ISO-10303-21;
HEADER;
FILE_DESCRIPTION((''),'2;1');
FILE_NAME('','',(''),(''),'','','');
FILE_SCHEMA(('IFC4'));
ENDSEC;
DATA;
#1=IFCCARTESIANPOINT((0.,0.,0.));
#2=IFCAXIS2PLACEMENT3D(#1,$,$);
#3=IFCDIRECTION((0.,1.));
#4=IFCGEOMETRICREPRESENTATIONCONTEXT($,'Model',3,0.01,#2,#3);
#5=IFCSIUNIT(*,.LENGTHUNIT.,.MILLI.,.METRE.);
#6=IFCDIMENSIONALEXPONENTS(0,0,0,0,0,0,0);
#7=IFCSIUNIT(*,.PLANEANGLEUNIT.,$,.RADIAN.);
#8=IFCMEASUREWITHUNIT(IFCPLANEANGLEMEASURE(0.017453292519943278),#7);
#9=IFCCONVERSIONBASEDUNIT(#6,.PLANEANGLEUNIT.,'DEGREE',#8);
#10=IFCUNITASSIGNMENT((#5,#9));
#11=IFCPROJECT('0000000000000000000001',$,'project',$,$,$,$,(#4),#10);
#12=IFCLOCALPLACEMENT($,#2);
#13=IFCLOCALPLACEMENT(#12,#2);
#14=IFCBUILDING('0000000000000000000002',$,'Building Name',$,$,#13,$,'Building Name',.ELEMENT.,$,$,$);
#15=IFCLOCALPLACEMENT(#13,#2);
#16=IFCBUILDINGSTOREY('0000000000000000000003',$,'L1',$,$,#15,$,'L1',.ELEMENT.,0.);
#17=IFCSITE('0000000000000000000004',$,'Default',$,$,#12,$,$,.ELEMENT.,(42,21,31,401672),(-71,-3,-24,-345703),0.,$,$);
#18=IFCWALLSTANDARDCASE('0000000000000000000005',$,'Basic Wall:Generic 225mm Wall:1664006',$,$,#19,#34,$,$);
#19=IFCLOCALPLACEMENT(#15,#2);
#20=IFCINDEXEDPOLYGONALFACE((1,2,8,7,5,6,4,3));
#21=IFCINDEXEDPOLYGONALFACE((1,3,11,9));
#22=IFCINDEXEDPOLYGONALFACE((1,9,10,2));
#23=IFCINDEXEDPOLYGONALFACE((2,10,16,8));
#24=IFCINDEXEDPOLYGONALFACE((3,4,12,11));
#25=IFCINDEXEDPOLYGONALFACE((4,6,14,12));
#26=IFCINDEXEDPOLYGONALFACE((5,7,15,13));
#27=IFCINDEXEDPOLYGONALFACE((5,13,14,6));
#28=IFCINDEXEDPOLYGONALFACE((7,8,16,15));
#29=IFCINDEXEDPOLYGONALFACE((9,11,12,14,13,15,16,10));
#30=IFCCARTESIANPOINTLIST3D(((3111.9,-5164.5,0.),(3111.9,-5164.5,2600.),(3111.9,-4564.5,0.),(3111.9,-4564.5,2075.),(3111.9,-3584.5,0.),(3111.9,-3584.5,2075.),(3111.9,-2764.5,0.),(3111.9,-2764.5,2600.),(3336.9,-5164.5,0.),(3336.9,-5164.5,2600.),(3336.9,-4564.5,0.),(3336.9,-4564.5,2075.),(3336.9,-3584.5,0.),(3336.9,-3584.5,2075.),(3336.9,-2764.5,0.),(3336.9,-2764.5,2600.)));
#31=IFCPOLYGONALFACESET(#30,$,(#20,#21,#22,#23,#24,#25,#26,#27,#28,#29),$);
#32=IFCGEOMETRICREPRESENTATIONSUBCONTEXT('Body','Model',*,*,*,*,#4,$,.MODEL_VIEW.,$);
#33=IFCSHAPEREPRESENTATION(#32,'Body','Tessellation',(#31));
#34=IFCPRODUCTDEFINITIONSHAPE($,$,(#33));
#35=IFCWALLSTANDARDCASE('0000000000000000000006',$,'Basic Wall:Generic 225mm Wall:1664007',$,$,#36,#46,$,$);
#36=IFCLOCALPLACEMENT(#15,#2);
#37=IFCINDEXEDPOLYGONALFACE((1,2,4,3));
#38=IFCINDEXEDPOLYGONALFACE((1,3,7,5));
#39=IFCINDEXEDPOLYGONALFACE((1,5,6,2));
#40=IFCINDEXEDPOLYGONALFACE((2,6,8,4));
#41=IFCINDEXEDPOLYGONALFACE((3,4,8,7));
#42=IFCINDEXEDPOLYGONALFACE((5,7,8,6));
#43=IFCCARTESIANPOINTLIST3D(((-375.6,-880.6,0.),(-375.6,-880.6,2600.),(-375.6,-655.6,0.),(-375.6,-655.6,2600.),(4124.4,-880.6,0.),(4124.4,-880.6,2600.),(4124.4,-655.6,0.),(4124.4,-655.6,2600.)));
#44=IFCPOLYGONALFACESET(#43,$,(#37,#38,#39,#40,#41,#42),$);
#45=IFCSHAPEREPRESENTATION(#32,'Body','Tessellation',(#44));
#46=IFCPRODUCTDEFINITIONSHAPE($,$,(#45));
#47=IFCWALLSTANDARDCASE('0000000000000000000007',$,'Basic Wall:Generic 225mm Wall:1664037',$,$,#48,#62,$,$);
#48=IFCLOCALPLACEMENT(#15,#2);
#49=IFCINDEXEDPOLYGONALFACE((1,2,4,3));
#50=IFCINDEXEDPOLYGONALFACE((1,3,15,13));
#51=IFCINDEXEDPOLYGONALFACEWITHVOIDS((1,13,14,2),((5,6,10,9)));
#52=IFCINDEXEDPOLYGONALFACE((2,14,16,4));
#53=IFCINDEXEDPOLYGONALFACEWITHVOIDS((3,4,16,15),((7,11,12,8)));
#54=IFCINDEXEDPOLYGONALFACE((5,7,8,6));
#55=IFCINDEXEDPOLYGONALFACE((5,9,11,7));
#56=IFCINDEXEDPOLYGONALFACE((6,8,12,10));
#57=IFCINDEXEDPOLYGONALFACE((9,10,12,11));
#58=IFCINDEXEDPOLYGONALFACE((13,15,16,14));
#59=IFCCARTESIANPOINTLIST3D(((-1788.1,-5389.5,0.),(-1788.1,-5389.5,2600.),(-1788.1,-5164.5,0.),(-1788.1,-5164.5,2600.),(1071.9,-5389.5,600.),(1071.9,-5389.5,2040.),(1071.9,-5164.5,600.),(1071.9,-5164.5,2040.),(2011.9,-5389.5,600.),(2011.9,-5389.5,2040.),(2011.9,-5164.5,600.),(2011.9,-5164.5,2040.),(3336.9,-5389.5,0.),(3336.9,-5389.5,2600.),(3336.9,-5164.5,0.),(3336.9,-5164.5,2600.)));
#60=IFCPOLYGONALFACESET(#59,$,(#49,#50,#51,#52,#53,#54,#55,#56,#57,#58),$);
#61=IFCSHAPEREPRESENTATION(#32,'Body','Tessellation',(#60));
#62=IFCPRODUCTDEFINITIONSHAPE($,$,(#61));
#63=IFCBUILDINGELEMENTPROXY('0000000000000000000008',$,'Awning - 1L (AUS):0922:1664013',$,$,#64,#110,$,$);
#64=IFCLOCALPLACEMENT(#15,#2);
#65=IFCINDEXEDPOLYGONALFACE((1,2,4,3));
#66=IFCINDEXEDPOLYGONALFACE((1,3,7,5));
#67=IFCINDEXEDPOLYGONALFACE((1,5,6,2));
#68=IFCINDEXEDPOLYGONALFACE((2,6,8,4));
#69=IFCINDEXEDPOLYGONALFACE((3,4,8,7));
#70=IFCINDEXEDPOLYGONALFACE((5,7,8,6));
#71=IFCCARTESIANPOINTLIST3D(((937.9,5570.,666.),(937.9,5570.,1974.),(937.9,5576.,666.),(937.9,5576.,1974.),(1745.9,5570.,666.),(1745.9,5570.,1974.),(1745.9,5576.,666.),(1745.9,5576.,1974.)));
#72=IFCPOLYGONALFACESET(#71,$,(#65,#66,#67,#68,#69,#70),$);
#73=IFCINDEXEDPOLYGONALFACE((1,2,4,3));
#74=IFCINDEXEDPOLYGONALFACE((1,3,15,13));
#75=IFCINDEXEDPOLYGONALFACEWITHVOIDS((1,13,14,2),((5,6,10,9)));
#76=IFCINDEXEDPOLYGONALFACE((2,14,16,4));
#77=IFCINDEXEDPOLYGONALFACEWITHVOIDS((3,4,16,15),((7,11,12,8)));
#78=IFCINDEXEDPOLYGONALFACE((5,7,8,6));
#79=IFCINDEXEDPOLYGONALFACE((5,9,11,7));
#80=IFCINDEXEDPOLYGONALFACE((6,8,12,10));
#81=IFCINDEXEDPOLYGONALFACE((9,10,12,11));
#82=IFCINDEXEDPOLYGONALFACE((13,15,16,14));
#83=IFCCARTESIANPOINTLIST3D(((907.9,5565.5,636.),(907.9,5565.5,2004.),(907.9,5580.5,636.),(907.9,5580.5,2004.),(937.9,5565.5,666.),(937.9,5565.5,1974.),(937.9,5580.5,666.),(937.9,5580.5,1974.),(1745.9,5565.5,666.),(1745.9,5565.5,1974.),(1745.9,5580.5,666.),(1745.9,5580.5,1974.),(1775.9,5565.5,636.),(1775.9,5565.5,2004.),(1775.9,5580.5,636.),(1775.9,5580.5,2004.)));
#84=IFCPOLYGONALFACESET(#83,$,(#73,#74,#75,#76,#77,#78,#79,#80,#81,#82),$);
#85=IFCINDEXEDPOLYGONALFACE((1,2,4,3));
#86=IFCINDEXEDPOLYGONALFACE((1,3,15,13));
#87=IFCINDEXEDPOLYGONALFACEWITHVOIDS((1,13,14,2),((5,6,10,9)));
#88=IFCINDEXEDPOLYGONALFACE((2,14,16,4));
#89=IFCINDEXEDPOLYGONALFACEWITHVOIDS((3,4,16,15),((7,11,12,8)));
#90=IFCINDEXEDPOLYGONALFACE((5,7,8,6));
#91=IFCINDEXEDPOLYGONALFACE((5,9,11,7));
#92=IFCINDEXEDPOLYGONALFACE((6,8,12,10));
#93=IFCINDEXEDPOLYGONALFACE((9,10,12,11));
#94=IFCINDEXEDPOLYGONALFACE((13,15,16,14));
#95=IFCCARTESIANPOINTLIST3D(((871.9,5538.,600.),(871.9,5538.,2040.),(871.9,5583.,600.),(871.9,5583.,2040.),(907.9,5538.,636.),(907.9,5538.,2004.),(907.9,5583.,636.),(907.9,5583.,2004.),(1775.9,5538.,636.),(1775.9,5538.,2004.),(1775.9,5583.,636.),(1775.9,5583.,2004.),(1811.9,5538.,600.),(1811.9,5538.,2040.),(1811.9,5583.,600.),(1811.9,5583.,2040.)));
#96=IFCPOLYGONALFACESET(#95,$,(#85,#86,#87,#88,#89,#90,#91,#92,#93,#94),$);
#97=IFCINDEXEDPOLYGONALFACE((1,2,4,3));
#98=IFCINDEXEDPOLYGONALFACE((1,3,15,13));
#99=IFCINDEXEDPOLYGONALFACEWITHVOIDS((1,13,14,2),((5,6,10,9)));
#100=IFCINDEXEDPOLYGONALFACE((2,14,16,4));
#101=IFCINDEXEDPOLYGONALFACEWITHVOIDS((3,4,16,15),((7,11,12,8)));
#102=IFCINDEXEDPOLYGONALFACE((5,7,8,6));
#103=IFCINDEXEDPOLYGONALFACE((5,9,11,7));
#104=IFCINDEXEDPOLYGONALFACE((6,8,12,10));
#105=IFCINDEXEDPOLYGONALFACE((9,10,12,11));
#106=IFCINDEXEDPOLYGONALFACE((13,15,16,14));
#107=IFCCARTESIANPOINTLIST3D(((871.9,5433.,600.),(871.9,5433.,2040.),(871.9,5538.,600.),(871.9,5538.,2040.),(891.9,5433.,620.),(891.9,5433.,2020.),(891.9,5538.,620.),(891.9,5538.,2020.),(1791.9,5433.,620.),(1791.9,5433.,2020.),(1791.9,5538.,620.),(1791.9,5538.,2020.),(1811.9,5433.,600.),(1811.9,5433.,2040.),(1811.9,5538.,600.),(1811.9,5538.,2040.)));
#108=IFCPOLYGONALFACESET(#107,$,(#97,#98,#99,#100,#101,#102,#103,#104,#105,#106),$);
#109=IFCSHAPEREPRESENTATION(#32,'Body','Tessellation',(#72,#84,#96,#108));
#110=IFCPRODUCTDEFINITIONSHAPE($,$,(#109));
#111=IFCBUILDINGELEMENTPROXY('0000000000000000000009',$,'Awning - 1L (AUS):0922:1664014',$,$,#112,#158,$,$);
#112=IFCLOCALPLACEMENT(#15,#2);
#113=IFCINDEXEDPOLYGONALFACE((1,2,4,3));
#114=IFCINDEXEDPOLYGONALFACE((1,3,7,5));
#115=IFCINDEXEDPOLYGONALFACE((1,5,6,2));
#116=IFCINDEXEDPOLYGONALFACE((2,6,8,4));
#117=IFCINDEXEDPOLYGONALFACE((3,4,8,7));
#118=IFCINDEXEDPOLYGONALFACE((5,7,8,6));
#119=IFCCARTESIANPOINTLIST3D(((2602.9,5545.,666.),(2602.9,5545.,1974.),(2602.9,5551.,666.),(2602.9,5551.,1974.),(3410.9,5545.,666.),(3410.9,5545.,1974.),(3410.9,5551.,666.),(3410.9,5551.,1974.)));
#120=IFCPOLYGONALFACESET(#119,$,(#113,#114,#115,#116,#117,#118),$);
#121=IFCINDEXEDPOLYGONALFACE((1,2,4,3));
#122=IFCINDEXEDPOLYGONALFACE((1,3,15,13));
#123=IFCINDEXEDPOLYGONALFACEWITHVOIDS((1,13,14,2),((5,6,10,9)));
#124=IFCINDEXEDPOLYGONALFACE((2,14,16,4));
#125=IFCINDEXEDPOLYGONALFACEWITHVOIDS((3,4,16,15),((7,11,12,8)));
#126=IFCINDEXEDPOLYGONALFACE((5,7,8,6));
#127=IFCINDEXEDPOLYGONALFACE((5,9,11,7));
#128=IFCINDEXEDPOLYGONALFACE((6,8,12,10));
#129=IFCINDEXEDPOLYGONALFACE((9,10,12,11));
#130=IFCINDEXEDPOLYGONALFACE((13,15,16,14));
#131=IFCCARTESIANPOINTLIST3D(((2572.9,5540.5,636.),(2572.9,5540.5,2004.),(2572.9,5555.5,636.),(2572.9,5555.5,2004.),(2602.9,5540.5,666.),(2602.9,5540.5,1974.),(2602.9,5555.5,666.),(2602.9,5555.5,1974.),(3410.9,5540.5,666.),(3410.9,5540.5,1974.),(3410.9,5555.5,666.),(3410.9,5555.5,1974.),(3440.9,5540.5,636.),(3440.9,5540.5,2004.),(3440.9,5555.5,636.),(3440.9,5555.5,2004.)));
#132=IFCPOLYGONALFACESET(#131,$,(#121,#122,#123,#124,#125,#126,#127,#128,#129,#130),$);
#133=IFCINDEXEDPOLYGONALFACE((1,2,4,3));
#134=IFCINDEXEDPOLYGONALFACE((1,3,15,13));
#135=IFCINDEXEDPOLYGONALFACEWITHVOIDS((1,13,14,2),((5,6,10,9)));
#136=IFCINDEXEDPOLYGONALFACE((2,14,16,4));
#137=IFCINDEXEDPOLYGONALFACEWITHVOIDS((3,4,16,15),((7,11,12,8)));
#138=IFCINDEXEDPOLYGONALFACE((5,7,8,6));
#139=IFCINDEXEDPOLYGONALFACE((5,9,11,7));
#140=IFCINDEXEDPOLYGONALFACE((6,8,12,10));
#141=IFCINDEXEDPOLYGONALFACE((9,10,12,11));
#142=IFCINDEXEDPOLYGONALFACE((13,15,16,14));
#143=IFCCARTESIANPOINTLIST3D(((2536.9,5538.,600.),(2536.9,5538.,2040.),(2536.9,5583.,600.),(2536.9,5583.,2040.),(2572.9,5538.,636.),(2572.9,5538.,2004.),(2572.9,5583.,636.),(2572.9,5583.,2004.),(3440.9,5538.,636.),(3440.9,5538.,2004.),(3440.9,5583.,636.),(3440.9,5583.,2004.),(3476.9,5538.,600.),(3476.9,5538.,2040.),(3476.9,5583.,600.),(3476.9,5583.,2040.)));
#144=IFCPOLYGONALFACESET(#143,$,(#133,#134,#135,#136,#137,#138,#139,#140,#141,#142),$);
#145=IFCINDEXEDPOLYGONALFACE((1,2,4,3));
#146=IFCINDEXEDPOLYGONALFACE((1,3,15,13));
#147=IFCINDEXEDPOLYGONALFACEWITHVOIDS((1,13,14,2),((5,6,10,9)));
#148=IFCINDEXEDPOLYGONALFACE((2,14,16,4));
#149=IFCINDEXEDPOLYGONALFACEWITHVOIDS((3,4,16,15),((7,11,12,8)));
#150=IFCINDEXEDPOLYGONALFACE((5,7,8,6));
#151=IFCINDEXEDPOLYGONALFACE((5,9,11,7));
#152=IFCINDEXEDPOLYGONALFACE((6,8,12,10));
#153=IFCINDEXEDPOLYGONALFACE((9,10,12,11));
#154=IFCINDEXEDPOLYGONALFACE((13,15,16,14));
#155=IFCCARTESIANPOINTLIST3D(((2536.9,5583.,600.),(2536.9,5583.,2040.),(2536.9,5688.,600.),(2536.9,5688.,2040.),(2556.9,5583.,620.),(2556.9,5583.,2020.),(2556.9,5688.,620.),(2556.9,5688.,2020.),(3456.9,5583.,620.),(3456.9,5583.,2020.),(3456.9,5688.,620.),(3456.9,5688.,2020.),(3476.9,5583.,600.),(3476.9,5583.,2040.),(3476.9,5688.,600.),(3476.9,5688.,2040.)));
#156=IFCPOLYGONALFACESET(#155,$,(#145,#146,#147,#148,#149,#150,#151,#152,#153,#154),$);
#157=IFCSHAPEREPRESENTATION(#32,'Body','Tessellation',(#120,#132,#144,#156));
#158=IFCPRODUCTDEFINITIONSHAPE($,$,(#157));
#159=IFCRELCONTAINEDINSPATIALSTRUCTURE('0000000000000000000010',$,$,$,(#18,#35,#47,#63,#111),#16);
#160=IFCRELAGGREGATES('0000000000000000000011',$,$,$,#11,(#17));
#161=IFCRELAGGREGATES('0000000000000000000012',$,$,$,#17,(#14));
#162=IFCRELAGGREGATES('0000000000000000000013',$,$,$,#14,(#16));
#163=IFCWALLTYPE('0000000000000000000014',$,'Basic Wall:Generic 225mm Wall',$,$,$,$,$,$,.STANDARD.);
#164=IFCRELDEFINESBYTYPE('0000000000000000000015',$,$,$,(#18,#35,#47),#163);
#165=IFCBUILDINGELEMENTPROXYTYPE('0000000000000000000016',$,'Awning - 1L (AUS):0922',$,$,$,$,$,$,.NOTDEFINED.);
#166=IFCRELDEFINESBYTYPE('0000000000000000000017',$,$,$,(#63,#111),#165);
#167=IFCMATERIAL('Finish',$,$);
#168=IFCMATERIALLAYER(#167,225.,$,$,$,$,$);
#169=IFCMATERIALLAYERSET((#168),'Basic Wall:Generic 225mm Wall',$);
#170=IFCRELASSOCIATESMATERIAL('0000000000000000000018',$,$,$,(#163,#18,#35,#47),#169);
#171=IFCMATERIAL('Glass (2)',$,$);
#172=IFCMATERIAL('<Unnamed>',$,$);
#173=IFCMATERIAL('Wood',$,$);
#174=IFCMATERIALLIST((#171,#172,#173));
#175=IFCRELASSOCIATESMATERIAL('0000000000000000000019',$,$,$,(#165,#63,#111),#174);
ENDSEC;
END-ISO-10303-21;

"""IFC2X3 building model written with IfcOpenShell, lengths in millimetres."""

from ifc_helpers import new_model, entity, si_unit, converted_unit, direction, frame, frame_2d, origin, place, context, subcontext, project, spatial, polyline, rectangle, outline, extrude, source, transform, mapped, material, material_list, layer, layer_set, layer_usage, type_object, type_shapes, element, save


model = new_model("IFC2X3")

# Units and contexts
model_context = context("Model", 3, precision=0.01, world=origin(), true_north=direction((0.0, 1.0)))
body_context = subcontext(model_context, "Body", "Model", "MODEL_VIEW")
ifc_project = project(units=[si_unit("LENGTHUNIT", "METRE", prefix="MILLI"), converted_unit("PLANEANGLEUNIT", "DEGREE", entity("IfcPlaneAngleMeasure", 0.017453292519943278), si_unit("PLANEANGLEUNIT", "RADIAN"), dimensions=[0, 0, 0, 0, 0, 0, 0])], contexts=[model_context])

# Site, building, storey
site_placement = place(None, origin())
site = spatial("IfcSite", under=ifc_project, at=site_placement, Name="Default", CompositionType="ELEMENT", RefLatitude=(42, 21, 31, 401672), RefLongitude=(-71, -3, -24, -345703), RefElevation=0.0)
building_placement = place(site_placement, origin())
building = spatial("IfcBuilding", under=site, at=building_placement, Name="Building Name", LongName="Building Name", CompositionType="ELEMENT")
storey_placement = place(building_placement, origin())
storey = spatial("IfcBuildingStorey", under=building, at=storey_placement, Name="L1", LongName="L1", CompositionType="ELEMENT", Elevation=0.0)

# Shared definitions
ifc_material_1 = material(Name="Finish")
ifc_layer = layer(ifc_material_1, 225.0)
ifc_layer_set = layer_set([ifc_layer], Name="Basic Wall:Generic 225mm Wall")
wall_type = type_object("IfcWallType", Name="Basic Wall:Generic 225mm Wall", PredefinedType="STANDARD", material=ifc_layer_set)

# Wall, opening
ifc_layer_usage_1 = layer_usage(ifc_layer_set, "AXIS2", "NEGATIVE", 112.5)
wall_1_placement = place(storey_placement, frame((3224.4, -5164.5, 0.0), z_axis=(0.0, 0.0, 1.0), x_axis=(0.0, 1.0, 0.0)))
wall_1 = element("IfcWallStandardCase", 1, at=wall_1_placement, inside=storey, type_object=wall_type, material=ifc_layer_usage_1, Name="Basic Wall:Generic 225mm Wall:1664006", context=body_context, shape_type="SweptSolid", body=[
    extrude(rectangle(XDim=2400.0, YDim=225.0, at=frame_2d((1200.0, 0.0), x_axis=(1.0, 0.0))), origin(), (0.0, 0.0, 1.0), 2600.0),
])
opening_1_placement = place(wall_1_placement, frame((600.0, -112.5, 0.0)))
element("IfcOpeningElement", 2, at=opening_1_placement, cuts=wall_1, ObjectType="Opening", context=body_context, shape_type="SweptSolid", body=[
    extrude(rectangle(XDim=980.0, YDim=2075.0, at=frame_2d((1037.5, 490.0), x_axis=(0.0, 1.0))), frame((0.0, 0.0, 0.0), z_axis=(0.0, 1.0, 0.0), x_axis=(0.0, 0.0, 1.0)), (0.0, 0.0, 1.0), 225.0),
])

# Wall
ifc_layer_usage_2 = layer_usage(ifc_layer_set, "AXIS2", "NEGATIVE", 112.5)
wall_2_placement = place(storey_placement, frame((4124.4, -768.1, 0.0), z_axis=(0.0, 0.0, 1.0), x_axis=(-1.0, 0.0, 0.0)))
element("IfcWallStandardCase", 3, at=wall_2_placement, inside=storey, type_object=wall_type, material=ifc_layer_usage_2, Name="Basic Wall:Generic 225mm Wall:1664007", context=body_context, shape_type="SweptSolid", body=[
    extrude(rectangle(XDim=4500.0, YDim=225.0, at=frame_2d((2250.0, 0.0), x_axis=(-1.0, 0.0))), origin(), (0.0, 0.0, 1.0), 2600.0),
])

# Wall, opening
ifc_layer_usage_3 = layer_usage(ifc_layer_set, "AXIS2", "NEGATIVE", 112.5)
wall_3_placement = place(storey_placement, frame((3336.9, -5277.0, 0.0), z_axis=(0.0, 0.0, 1.0), x_axis=(-1.0, 0.0, 0.0)))
wall_3 = element("IfcWallStandardCase", 4, at=wall_3_placement, inside=storey, type_object=wall_type, material=ifc_layer_usage_3, Name="Basic Wall:Generic 225mm Wall:1664037", context=body_context, shape_type="SweptSolid", body=[
    extrude(rectangle(XDim=5125.0, YDim=225.0, at=frame_2d((2562.5, 0.0), x_axis=(-1.0, 0.0))), origin(), (0.0, 0.0, 1.0), 2600.0),
])
opening_2_placement = place(wall_3_placement, origin())
element("IfcOpeningElement", 5, at=opening_2_placement, cuts=wall_3, ObjectType="Opening", context=body_context, shape_type="SweptSolid", body=[
    extrude(rectangle(XDim=1440.0, YDim=940.0, at=frame_2d((0.0, 0.0), x_axis=(0.0, 1.0))), frame((1795.0, -112.5, 1320.0), z_axis=(0.0, 1.0, 0.0), x_axis=(-1.0, 0.0, 0.0)), (0.0, 0.0, 1.0), 225.0),
])

# Building element proxies
ifc_material_2 = material(Name="Glass (2)")
ifc_material_3 = material(Name="<Unnamed>")
ifc_material_4 = material(Name="Wood")
ifc_material_list = material_list([ifc_material_2, ifc_material_3, ifc_material_4])
building_element_proxy_type_1 = type_object("IfcBuildingElementProxyType", Name="Awning - 1L (AUS):0922", PredefinedType="NOTDEFINED", material=ifc_material_list)
shared_shape = source(origin(), body_context, "Body", "SweptSolid", [
    extrude(rectangle(XDim=6.0, YDim=808.0, at=frame_2d((0.0, 0.0), x_axis=(1.0, 0.0))), frame((326.2, 12.5, 966.0), z_axis=(0.0, 0.0, 1.0), x_axis=(0.0, 1.0, 0.0)), (0.0, 0.0, 1.0), 1308.0),
    extrude(outline(polyline([(-684.0, -434.0), (684.0, -434.0), (684.0, 434.0), (-684.0, 434.0), (-684.0, -434.0)]), holes=[polyline([(654.0, -404.0), (-654.0, -404.0), (-654.0, 404.0), (654.0, 404.0), (654.0, -404.0)])]), frame((326.2, 5.0, 1620.0), z_axis=(0.0, 1.0, 0.0), x_axis=(0.0, 0.0, 1.0)), (0.0, 0.0, 1.0), 15.0),
    extrude(outline(polyline([(-720.0, -470.0), (720.0, -470.0), (720.0, 470.0), (-720.0, 470.0), (-720.0, -470.0)]), holes=[polyline([(684.0, -434.0), (-684.0, -434.0), (-684.0, 434.0), (684.0, 434.0), (684.0, -434.0)])]), frame((326.2, -22.5, 1620.0), z_axis=(0.0, 1.0, 0.0), x_axis=(0.0, 0.0, 1.0)), (0.0, 0.0, 1.0), 45.0),
    extrude(outline(polyline([(-720.0, -470.0), (720.0, -470.0), (720.0, 470.0), (-720.0, 470.0), (-720.0, -470.0)]), holes=[polyline([(700.0, -450.0), (-700.0, -450.0), (-700.0, 450.0), (700.0, 450.0), (700.0, -450.0)])]), frame((326.2, -127.5, 1620.0), z_axis=(0.0, 1.0, 0.0), x_axis=(0.0, 0.0, 1.0)), (0.0, 0.0, 1.0), 105.0),
])
type_shapes(building_element_proxy_type_1, [shared_shape])
proxy_1_placement = place(storey_placement, frame((1015.7, 5560.5, -300.0)))
element("IfcBuildingElementProxy", 6, at=proxy_1_placement, inside=storey, type_object=building_element_proxy_type_1, material=ifc_material_list, Name="Awning - 1L (AUS):0922:1664013", context=body_context, shape_type="MappedRepresentation", body=[
    mapped(shared_shape, transform((0.0, 0.0, 0.0), scale=1.0)),
])
for number, where, z_axis, x_axis, name in (
    (7, (3333.1, 5560.5, -300.0), (0.0, 0.0, 1.0), (-1.0, 0.0, 0.0), "Awning - 1L (AUS):0922:1664014"),
):
    element("IfcBuildingElementProxy", number, at=place(storey_placement, frame(where, z_axis=z_axis, x_axis=x_axis)), inside=storey, type_object=building_element_proxy_type_1, material=ifc_material_list, Name=name, context=body_context, shape_type="MappedRepresentation", body=[
        mapped(shared_shape, transform((0.0, 0.0, 0.0), scale=1.0)),
    ])

save(model, "model.ifc")
